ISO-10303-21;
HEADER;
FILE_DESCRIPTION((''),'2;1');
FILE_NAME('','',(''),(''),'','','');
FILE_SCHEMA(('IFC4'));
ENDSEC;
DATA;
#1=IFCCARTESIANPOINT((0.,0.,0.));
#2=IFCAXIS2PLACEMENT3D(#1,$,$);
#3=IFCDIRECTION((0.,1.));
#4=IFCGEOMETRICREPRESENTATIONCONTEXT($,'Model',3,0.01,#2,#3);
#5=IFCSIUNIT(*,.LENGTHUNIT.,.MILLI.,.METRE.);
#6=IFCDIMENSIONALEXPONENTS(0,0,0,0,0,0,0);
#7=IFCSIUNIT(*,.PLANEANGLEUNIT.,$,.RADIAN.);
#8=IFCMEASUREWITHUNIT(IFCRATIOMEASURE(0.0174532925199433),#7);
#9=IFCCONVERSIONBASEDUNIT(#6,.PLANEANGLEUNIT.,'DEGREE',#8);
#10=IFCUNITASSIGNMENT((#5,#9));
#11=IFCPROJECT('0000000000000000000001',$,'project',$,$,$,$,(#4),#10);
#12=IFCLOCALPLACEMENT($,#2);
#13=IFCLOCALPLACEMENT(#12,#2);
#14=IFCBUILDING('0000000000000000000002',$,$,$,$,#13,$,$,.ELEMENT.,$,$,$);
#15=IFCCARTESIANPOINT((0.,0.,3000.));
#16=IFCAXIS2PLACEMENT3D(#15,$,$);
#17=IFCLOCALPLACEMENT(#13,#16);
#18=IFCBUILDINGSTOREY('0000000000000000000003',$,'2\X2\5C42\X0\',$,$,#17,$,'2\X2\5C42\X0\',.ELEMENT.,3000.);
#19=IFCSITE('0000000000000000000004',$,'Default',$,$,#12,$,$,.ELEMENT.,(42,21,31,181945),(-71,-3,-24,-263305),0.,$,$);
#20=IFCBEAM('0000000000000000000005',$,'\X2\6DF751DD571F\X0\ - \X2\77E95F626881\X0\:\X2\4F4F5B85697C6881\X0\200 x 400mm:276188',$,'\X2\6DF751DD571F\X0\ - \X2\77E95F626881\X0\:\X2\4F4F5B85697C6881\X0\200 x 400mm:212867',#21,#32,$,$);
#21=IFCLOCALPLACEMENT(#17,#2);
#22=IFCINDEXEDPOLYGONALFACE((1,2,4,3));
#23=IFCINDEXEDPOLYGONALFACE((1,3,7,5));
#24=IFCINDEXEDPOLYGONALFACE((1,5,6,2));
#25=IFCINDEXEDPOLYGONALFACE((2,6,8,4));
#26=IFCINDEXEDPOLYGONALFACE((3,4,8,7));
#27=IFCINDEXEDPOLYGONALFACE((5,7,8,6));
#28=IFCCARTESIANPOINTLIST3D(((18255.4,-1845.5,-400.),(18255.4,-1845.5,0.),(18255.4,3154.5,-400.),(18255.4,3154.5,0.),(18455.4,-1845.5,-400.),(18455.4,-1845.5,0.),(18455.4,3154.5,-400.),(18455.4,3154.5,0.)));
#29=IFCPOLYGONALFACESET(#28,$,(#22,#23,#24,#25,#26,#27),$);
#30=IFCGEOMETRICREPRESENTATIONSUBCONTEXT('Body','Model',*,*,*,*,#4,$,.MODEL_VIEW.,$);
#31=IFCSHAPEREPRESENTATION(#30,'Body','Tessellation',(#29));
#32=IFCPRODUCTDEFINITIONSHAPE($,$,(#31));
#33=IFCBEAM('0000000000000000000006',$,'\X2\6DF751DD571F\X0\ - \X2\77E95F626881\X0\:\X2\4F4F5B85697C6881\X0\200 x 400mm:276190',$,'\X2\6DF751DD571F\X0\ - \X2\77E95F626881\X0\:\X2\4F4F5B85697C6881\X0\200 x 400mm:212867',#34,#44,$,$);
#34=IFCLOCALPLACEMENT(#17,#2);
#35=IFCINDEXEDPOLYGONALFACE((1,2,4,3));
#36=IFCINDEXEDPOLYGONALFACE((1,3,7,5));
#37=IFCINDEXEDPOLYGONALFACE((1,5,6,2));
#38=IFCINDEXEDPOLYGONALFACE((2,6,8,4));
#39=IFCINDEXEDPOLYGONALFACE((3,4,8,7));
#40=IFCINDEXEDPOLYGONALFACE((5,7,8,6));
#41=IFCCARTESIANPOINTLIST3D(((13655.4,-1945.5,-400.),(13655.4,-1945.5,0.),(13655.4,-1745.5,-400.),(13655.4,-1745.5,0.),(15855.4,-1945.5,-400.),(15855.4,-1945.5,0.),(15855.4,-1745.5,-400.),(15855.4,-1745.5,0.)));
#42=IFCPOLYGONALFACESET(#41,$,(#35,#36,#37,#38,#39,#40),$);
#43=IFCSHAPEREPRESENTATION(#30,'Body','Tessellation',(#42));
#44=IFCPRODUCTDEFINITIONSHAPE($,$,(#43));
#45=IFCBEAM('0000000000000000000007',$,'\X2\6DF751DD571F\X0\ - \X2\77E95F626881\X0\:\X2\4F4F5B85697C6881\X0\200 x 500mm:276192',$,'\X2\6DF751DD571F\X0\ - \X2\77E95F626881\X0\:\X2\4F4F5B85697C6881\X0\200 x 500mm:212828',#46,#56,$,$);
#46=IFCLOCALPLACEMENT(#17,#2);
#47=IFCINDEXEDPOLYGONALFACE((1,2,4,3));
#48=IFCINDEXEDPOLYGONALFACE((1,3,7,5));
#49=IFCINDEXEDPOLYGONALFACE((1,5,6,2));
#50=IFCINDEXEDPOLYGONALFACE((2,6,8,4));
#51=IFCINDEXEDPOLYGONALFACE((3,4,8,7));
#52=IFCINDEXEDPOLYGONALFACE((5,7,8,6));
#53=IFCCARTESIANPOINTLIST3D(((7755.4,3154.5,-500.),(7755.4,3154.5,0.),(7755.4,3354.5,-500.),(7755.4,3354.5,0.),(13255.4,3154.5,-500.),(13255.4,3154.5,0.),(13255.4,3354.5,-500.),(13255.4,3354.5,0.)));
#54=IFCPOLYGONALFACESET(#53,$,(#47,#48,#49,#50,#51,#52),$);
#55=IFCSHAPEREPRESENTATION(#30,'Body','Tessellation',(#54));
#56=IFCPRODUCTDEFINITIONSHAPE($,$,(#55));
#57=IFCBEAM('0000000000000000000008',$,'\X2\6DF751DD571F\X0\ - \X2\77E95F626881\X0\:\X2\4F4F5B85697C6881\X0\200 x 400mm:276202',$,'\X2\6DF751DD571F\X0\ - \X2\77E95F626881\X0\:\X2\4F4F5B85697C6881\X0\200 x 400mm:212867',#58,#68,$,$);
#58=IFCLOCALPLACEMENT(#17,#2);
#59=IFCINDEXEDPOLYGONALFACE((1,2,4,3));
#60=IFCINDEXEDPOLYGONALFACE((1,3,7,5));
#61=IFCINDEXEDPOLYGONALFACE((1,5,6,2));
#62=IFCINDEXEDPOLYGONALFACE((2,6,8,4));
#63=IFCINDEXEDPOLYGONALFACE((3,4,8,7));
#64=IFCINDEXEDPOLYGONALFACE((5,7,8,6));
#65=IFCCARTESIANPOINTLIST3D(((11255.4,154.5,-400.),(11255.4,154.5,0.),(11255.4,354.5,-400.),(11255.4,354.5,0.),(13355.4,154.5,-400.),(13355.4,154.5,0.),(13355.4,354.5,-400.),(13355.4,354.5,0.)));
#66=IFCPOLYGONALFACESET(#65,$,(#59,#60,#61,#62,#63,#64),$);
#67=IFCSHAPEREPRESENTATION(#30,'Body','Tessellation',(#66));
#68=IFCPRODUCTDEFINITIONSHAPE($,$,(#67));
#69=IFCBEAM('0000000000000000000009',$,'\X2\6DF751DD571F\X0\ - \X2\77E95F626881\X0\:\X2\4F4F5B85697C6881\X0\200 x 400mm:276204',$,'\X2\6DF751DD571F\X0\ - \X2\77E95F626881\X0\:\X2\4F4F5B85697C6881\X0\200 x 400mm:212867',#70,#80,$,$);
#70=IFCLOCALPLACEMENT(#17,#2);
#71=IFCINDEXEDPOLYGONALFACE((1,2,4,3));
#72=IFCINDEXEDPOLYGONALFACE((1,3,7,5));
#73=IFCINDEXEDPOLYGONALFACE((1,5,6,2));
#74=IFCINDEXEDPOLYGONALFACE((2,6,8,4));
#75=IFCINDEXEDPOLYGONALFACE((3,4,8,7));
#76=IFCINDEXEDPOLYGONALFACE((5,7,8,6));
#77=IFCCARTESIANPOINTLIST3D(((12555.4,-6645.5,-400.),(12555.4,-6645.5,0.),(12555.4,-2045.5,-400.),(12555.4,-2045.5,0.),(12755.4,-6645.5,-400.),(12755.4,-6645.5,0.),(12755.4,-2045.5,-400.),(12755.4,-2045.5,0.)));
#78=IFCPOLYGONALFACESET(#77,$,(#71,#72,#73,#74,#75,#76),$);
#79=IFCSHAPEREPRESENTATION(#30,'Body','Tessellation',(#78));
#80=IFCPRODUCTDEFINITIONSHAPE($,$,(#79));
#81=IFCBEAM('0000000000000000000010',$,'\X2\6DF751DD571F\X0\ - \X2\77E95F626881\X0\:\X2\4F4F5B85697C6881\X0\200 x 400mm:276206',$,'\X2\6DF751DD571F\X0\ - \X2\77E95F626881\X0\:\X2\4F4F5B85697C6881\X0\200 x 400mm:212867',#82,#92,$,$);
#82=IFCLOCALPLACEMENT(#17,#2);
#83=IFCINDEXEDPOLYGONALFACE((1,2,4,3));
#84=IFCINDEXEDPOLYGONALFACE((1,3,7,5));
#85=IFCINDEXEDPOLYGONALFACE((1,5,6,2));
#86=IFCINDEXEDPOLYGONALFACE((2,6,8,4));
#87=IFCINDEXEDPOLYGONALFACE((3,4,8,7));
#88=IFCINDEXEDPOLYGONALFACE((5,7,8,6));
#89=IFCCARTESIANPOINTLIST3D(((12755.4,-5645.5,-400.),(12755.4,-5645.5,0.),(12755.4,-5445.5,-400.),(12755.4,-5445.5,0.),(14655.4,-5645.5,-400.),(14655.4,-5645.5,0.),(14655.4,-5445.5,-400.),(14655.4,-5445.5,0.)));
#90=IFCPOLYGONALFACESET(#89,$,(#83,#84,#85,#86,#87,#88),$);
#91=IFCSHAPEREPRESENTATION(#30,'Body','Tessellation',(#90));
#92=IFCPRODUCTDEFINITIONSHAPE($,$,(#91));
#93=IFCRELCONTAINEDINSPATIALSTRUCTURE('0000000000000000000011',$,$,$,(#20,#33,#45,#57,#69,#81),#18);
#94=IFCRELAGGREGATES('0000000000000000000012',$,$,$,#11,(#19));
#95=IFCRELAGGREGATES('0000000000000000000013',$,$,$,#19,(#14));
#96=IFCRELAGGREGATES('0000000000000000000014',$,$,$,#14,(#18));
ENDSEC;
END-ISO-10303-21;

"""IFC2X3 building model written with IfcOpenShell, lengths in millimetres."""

from ifc_helpers import new_model, entity, si_unit, converted_unit, direction, frame, frame_2d, origin, origin_2d_with_axis, place, context, subcontext, project, spatial, rectangle, extrude, element, save


model = new_model("IFC2X3")

# Units and contexts
model_context = context("Model", 3, precision=0.01, world=origin(), true_north=direction((0.0, 1.0)))
body_context = subcontext(model_context, "Body", "Model", "MODEL_VIEW")
ifc_project = project(units=[si_unit("LENGTHUNIT", "METRE", prefix="MILLI"), converted_unit("PLANEANGLEUNIT", "DEGREE", entity("IfcRatioMeasure", 0.0174532925199433), si_unit("PLANEANGLEUNIT", "RADIAN"), dimensions=[0, 0, 0, 0, 0, 0, 0])], contexts=[model_context])

# Site, building, storey
site_placement = place(None, origin())
site = spatial("IfcSite", under=ifc_project, at=site_placement, Name="Default", CompositionType="ELEMENT", RefLatitude=(42, 21, 31, 181945), RefLongitude=(-71, -3, -24, -263305), RefElevation=0.0)
building_placement = place(site_placement, origin())
building = spatial("IfcBuilding", under=site, at=building_placement, CompositionType="ELEMENT")
storey_placement = place(building_placement, frame((0.0, 0.0, 3000.0)))
storey = spatial("IfcBuildingStorey", under=building, at=storey_placement, Name="2层", LongName="2层", CompositionType="ELEMENT", Elevation=3000.0)

# Beams
beam_1_placement = place(storey_placement, frame((18355.4, 3254.5, 0.0), z_axis=(0.0, 0.0, 1.0), x_axis=(0.0, -1.0, 0.0)))
element("IfcBeam", 1, at=beam_1_placement, inside=storey, Name="混凝土 - 矩形梁:住宅楼梁200 x 400mm:276188", ObjectType="混凝土 - 矩形梁:住宅楼梁200 x 400mm:212867", context=body_context, shape_type="SweptSolid", body=[
    extrude(rectangle(XDim=400.0, YDim=200.0, at=frame_2d((0.0, 0.0), x_axis=(1.0, 0.0))), frame((100.0, 0.0, -200.0), z_axis=(1.0, 0.0, 0.0), x_axis=(0.0, 0.0, -1.0)), (0.0, 0.0, 1.0), 5000.0),
])
beam_2_placement = place(storey_placement, frame((16055.4, -1845.5, 0.0), z_axis=(0.0, 0.0, 1.0), x_axis=(-1.0, 0.0, 0.0)))
element("IfcBeam", 2, at=beam_2_placement, inside=storey, Name="混凝土 - 矩形梁:住宅楼梁200 x 400mm:276190", ObjectType="混凝土 - 矩形梁:住宅楼梁200 x 400mm:212867", context=body_context, shape_type="SweptSolid", body=[
    extrude(rectangle(XDim=400.0, YDim=200.0, at=frame_2d((0.0, 0.0), x_axis=(1.0, 0.0))), frame((200.0, 0.0, -200.0), z_axis=(1.0, 0.0, 0.0), x_axis=(0.0, 0.0, -1.0)), (0.0, 0.0, 1.0), 2200.0),
])
beam_3_placement = place(storey_placement, frame((7555.4, 3254.5, 0.0)))
element("IfcBeam", 3, at=beam_3_placement, inside=storey, Name="混凝土 - 矩形梁:住宅楼梁200 x 500mm:276192", ObjectType="混凝土 - 矩形梁:住宅楼梁200 x 500mm:212828", context=body_context, shape_type="SweptSolid", body=[
    extrude(rectangle(XDim=500.0, YDim=200.0, at=frame_2d((0.0, 0.0), x_axis=(1.0, 0.0))), frame((200.0, 0.0, -250.0), z_axis=(1.0, 0.0, 0.0), x_axis=(0.0, 0.0, -1.0)), (0.0, 0.0, 1.0), 5500.0),
])
beam_4_placement = place(storey_placement, frame((11155.4, 254.5, 0.0)))
element("IfcBeam", 4, at=beam_4_placement, inside=storey, Name="混凝土 - 矩形梁:住宅楼梁200 x 400mm:276202", ObjectType="混凝土 - 矩形梁:住宅楼梁200 x 400mm:212867", context=body_context, shape_type="SweptSolid", body=[
    extrude(rectangle(XDim=400.0, YDim=200.0, at=frame_2d((0.0, 0.0), x_axis=(1.0, 0.0))), frame((100.0, 0.0, -200.0), z_axis=(1.0, 0.0, 0.0), x_axis=(0.0, 0.0, -1.0)), (0.0, 0.0, 1.0), 2100.0),
])
beam_5_placement = place(storey_placement, frame((12655.4, -1945.5, 0.0), z_axis=(0.0, 0.0, 1.0), x_axis=(0.0, -1.0, 0.0)))
element("IfcBeam", 5, at=beam_5_placement, inside=storey, Name="混凝土 - 矩形梁:住宅楼梁200 x 400mm:276204", ObjectType="混凝土 - 矩形梁:住宅楼梁200 x 400mm:212867", context=body_context, shape_type="SweptSolid", body=[
    extrude(rectangle(XDim=400.0, YDim=200.0, at=origin_2d_with_axis()), frame((100.0, 0.0, -200.0), z_axis=(1.0, 0.0, 0.0), x_axis=(0.0, 0.0, -1.0)), (0.0, 0.0, 1.0), 4600.0),
])
beam_6_placement = place(storey_placement, frame((12655.4, -5545.5, 0.0)))
element("IfcBeam", 6, at=beam_6_placement, inside=storey, Name="混凝土 - 矩形梁:住宅楼梁200 x 400mm:276206", ObjectType="混凝土 - 矩形梁:住宅楼梁200 x 400mm:212867", context=body_context, shape_type="SweptSolid", body=[
    extrude(rectangle(XDim=400.0, YDim=200.0, at=frame_2d((0.0, 0.0), x_axis=(1.0, 0.0))), frame((100.0, 0.0, -200.0), z_axis=(1.0, 0.0, 0.0), x_axis=(0.0, 0.0, -1.0)), (0.0, 0.0, 1.0), 1900.0),
])

save(model, "model.ifc")
